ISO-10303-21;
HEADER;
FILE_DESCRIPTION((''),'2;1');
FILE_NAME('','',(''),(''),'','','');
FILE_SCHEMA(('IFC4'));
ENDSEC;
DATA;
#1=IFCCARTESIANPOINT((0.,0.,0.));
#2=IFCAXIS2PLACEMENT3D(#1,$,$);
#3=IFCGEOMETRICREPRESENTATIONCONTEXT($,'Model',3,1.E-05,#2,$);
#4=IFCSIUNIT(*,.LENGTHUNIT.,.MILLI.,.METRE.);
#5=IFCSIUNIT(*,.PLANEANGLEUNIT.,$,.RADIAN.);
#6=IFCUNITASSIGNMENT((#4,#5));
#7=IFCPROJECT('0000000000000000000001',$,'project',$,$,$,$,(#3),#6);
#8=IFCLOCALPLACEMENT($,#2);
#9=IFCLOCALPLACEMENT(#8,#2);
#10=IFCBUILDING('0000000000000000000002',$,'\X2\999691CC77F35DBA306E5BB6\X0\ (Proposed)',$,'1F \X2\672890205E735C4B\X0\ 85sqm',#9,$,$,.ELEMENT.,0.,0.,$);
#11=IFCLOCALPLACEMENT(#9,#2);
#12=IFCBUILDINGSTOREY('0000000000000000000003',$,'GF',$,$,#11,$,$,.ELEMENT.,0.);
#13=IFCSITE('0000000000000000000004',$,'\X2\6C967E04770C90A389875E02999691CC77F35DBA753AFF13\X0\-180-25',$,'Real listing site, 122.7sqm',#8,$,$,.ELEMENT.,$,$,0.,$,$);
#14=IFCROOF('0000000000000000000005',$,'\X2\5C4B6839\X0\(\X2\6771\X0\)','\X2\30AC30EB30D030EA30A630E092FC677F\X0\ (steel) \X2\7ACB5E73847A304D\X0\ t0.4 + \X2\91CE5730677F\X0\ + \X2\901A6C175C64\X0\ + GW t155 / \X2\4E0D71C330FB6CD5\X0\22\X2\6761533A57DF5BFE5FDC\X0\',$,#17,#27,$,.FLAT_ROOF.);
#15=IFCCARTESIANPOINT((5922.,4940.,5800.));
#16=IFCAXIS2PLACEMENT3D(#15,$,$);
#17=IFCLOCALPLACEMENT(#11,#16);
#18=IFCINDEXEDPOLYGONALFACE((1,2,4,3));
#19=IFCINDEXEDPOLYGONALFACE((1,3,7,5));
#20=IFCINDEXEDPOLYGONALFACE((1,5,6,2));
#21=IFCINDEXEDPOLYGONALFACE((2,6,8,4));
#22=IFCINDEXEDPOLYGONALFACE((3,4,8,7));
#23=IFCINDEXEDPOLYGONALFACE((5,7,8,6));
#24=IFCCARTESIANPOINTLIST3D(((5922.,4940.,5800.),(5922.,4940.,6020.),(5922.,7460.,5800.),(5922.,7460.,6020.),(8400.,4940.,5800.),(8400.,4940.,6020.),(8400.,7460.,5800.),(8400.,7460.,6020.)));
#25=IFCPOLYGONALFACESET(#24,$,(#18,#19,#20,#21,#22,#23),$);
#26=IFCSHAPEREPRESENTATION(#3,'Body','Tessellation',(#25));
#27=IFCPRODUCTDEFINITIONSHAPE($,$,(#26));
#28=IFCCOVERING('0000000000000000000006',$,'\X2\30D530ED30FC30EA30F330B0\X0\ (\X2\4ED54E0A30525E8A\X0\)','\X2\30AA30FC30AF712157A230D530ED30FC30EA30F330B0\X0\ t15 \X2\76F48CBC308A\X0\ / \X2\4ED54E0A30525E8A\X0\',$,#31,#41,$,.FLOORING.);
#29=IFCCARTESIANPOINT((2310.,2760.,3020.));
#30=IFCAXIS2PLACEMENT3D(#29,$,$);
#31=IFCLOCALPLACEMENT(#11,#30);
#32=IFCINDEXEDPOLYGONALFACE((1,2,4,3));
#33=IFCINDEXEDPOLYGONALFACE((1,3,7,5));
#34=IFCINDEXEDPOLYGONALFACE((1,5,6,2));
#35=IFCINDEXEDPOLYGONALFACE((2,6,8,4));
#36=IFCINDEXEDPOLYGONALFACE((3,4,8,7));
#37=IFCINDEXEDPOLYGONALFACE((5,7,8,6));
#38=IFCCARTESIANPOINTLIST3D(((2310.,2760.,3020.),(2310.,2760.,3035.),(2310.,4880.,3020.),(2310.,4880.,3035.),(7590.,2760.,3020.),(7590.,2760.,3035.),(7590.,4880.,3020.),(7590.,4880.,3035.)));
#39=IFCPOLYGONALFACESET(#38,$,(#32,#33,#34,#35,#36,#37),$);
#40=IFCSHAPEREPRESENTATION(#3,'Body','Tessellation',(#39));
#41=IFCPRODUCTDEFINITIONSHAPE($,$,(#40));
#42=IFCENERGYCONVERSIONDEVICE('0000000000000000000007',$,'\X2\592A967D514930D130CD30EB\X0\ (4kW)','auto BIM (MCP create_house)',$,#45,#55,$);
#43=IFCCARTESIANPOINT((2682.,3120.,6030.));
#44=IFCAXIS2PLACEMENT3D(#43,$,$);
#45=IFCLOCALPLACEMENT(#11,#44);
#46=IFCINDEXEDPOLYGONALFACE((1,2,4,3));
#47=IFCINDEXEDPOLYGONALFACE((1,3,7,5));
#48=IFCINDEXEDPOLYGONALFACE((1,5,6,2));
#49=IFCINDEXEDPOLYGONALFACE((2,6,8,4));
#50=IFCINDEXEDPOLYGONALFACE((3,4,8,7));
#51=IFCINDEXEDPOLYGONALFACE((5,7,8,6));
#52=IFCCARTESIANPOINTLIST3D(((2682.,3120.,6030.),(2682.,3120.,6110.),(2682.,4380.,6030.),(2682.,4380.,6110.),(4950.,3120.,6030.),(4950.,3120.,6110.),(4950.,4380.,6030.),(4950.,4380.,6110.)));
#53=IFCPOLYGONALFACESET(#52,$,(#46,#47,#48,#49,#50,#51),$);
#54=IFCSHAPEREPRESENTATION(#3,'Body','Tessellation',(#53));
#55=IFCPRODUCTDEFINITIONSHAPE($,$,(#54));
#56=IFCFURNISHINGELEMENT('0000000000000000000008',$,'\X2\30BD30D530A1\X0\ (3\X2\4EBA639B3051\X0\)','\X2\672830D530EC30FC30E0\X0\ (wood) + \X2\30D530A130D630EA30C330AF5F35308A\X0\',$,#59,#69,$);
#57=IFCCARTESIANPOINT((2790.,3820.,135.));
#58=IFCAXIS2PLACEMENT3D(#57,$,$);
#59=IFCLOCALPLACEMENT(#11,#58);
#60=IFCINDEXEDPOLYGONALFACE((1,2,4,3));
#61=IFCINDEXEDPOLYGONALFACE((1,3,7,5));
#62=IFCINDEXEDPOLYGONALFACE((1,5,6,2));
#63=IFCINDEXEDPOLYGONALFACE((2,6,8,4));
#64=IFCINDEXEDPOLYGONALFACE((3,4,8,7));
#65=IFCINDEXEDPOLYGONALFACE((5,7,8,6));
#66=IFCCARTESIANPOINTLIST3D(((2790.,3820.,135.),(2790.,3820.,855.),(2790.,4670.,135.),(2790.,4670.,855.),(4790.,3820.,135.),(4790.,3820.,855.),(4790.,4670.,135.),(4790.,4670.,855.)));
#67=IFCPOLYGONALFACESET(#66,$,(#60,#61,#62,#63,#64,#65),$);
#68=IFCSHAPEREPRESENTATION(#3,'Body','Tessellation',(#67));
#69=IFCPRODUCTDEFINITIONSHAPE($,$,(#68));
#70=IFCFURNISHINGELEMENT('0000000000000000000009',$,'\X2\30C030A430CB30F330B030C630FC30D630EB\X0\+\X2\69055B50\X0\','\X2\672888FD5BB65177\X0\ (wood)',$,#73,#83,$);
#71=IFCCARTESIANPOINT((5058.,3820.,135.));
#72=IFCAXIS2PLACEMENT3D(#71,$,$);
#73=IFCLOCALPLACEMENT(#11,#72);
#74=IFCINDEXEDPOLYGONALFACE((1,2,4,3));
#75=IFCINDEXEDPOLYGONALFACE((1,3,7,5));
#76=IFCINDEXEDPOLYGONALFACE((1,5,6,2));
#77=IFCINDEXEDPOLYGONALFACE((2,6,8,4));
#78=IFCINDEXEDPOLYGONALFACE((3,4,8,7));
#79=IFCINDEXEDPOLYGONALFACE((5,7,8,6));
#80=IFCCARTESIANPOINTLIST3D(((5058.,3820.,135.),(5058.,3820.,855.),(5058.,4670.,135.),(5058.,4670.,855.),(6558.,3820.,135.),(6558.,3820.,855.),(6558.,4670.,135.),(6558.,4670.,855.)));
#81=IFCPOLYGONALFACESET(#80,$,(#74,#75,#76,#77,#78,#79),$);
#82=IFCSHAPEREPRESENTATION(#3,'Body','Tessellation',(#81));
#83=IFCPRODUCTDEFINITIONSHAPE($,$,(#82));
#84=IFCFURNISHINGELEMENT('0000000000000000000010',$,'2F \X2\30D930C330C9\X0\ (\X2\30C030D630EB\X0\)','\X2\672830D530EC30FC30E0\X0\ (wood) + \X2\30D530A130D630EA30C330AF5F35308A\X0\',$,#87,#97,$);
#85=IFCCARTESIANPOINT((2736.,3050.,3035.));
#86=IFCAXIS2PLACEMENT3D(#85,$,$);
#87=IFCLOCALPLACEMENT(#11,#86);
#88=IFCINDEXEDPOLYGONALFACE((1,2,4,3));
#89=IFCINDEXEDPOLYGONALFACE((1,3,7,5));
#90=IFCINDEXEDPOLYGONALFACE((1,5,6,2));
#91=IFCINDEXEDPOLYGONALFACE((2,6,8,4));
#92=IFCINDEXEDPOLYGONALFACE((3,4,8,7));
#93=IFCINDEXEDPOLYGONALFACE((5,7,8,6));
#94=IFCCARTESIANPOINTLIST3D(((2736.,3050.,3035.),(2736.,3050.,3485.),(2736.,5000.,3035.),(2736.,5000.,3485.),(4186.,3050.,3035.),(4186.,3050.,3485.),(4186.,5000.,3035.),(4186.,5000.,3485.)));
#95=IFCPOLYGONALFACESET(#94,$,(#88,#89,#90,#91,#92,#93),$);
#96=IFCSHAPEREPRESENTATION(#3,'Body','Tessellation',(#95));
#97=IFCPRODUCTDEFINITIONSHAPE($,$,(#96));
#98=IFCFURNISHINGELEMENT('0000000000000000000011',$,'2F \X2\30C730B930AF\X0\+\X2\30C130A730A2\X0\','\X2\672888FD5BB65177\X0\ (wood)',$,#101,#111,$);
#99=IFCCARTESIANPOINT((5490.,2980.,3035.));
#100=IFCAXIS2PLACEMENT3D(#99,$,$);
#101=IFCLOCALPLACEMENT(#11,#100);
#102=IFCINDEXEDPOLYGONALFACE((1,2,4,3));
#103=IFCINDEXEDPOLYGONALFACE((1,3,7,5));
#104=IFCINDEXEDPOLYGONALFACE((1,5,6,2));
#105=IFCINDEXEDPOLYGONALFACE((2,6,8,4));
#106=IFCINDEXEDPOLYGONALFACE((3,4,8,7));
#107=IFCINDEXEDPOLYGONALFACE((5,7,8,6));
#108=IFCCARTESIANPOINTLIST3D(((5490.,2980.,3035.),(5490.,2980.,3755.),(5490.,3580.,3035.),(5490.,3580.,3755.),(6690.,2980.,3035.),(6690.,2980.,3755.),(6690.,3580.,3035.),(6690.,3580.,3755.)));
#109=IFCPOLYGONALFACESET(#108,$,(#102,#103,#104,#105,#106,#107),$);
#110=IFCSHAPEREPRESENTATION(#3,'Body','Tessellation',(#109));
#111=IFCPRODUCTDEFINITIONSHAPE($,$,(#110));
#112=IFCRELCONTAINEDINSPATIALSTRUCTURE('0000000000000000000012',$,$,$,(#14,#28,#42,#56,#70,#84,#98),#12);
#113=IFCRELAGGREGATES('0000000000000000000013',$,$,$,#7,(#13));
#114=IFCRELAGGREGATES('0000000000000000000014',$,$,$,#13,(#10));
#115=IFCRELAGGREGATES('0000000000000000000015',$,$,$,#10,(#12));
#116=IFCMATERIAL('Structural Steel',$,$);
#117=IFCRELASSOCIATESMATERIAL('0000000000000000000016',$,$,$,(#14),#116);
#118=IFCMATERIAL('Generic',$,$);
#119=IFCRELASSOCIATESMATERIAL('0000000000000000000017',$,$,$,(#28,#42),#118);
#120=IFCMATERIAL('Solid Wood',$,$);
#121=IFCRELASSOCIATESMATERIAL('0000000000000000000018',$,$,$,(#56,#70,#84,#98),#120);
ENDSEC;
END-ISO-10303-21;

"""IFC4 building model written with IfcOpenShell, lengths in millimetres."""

from ifc_helpers import new_model, si_unit, frame, frame_2d, origin, place, context, project, spatial, rectangle, extrude, material, element, save


model = new_model("IFC4")

# Units and contexts
model_context = context("Model", 3, precision=1e-05, world=origin())
ifc_project = project(units=[si_unit("LENGTHUNIT", "METRE", prefix="MILLI"), si_unit("PLANEANGLEUNIT", "RADIAN")], contexts=[model_context])

# Site, building, storey
site_placement = place(None, origin())
site = spatial("IfcSite", under=ifc_project, at=site_placement, Name="沖縄県那覇市首里石嶺町３-180-25", ObjectType="Real listing site, 122.7sqm", CompositionType="ELEMENT", RefElevation=0.0)
building_placement = place(site_placement, origin())
building = spatial("IfcBuilding", under=site, at=building_placement, Name="首里石嶺の家 (Proposed)", ObjectType="1F 木造平屋 85sqm", CompositionType="ELEMENT", ElevationOfRefHeight=0.0, ElevationOfTerrain=0.0)
storey_placement = place(building_placement, origin())
storey = spatial("IfcBuildingStorey", under=building, at=storey_placement, Name="GF", CompositionType="ELEMENT", Elevation=0.0)

# Shared definitions
ifc_material_1 = material(Name="Solid Wood")

# Roof
ifc_material_2 = material(Name="Structural Steel")
roof_1_placement = place(storey_placement, frame((5922.0, 4940.0, 5800.0)))
element("IfcRoof", 1, at=roof_1_placement, inside=storey, material=ifc_material_2, Name="屋根(東)", Description="ガルバリウム鋼板 (steel) 立平葺き t0.4 + 野地板 + 通気層 + GW t155 / 不燃・法22条区域対応", PredefinedType="FLAT_ROOF", context=model_context, shape_type="SweptSolid", body=[
    extrude(rectangle(XDim=2478.0, YDim=2520.0, at=frame_2d((1239.0, 1260.0))), frame((5922.0, 4940.0, 5800.0)), (0.0, 0.0, 1.0), 220.0),
])

# Covering
ifc_material_3 = material(Name="Generic")
covering_placement = place(storey_placement, frame((2310.0, 2760.0, 3020.0)))
element("IfcCovering", 2, at=covering_placement, inside=storey, material=ifc_material_3, Name="フローリング (仕上げ床)", Description="オーク無垢フローリング t15 直貼り / 仕上げ床", PredefinedType="FLOORING", context=model_context, shape_type="SweptSolid", body=[
    extrude(rectangle(XDim=5280.0, YDim=2120.0, at=frame_2d((2640.0, 1060.0))), frame((2310.0, 2760.0, 3020.0)), (0.0, 0.0, 1.0), 15.0),
])

# Energy conversion device
energy_conversion_device_placement = place(storey_placement, frame((2682.0, 3120.0, 6030.0)))
element("IfcEnergyConversionDevice", 3, at=energy_conversion_device_placement, inside=storey, material=ifc_material_3, Name="太陽光パネル (4kW)", Description="auto BIM (MCP create_house)", context=model_context, shape_type="SweptSolid", body=[
    extrude(rectangle(XDim=2268.0, YDim=1260.0, at=frame_2d((1134.0, 630.0))), frame((2682.0, 3120.0, 6030.0)), (0.0, 0.0, 1.0), 80.0),
])

# Furnishing elements
furnishing_1_placement = place(storey_placement, frame((2790.0, 3820.0, 135.0)))
element("IfcFurnishingElement", 4, at=furnishing_1_placement, inside=storey, material=ifc_material_1, Name="ソファ (3人掛け)", Description="木フレーム (wood) + ファブリック張り", context=model_context, shape_type="SweptSolid", body=[
    extrude(rectangle(XDim=2000.0, YDim=850.0, at=frame_2d((1000.0, 425.0))), frame((2790.0, 3820.0, 135.0)), (0.0, 0.0, 1.0), 720.0),
])
furnishing_2_placement = place(storey_placement, frame((5058.0, 3820.0, 135.0)))
element("IfcFurnishingElement", 5, at=furnishing_2_placement, inside=storey, material=ifc_material_1, Name="ダイニングテーブル+椅子", Description="木製家具 (wood)", context=model_context, shape_type="SweptSolid", body=[
    extrude(rectangle(XDim=1500.0, YDim=850.0, at=frame_2d((750.0, 425.0))), frame((5058.0, 3820.0, 135.0)), (0.0, 0.0, 1.0), 720.0),
])
furnishing_3_placement = place(storey_placement, frame((2736.0, 3050.0, 3035.0)))
element("IfcFurnishingElement", 6, at=furnishing_3_placement, inside=storey, material=ifc_material_1, Name="2F ベッド (ダブル)", Description="木フレーム (wood) + ファブリック張り", context=model_context, shape_type="SweptSolid", body=[
    extrude(rectangle(XDim=1450.0, YDim=1950.0, at=frame_2d((725.0, 975.0))), frame((2736.0, 3050.0, 3035.0)), (0.0, 0.0, 1.0), 450.0),
])
furnishing_4_placement = place(storey_placement, frame((5490.0, 2980.0, 3035.0)))
element("IfcFurnishingElement", 7, at=furnishing_4_placement, inside=storey, material=ifc_material_1, Name="2F デスク+チェア", Description="木製家具 (wood)", context=model_context, shape_type="SweptSolid", body=[
    extrude(rectangle(XDim=1200.0, YDim=600.0, at=frame_2d((600.0, 300.0))), frame((5490.0, 2980.0, 3035.0)), (0.0, 0.0, 1.0), 720.0),
])

save(model, "model.ifc")
